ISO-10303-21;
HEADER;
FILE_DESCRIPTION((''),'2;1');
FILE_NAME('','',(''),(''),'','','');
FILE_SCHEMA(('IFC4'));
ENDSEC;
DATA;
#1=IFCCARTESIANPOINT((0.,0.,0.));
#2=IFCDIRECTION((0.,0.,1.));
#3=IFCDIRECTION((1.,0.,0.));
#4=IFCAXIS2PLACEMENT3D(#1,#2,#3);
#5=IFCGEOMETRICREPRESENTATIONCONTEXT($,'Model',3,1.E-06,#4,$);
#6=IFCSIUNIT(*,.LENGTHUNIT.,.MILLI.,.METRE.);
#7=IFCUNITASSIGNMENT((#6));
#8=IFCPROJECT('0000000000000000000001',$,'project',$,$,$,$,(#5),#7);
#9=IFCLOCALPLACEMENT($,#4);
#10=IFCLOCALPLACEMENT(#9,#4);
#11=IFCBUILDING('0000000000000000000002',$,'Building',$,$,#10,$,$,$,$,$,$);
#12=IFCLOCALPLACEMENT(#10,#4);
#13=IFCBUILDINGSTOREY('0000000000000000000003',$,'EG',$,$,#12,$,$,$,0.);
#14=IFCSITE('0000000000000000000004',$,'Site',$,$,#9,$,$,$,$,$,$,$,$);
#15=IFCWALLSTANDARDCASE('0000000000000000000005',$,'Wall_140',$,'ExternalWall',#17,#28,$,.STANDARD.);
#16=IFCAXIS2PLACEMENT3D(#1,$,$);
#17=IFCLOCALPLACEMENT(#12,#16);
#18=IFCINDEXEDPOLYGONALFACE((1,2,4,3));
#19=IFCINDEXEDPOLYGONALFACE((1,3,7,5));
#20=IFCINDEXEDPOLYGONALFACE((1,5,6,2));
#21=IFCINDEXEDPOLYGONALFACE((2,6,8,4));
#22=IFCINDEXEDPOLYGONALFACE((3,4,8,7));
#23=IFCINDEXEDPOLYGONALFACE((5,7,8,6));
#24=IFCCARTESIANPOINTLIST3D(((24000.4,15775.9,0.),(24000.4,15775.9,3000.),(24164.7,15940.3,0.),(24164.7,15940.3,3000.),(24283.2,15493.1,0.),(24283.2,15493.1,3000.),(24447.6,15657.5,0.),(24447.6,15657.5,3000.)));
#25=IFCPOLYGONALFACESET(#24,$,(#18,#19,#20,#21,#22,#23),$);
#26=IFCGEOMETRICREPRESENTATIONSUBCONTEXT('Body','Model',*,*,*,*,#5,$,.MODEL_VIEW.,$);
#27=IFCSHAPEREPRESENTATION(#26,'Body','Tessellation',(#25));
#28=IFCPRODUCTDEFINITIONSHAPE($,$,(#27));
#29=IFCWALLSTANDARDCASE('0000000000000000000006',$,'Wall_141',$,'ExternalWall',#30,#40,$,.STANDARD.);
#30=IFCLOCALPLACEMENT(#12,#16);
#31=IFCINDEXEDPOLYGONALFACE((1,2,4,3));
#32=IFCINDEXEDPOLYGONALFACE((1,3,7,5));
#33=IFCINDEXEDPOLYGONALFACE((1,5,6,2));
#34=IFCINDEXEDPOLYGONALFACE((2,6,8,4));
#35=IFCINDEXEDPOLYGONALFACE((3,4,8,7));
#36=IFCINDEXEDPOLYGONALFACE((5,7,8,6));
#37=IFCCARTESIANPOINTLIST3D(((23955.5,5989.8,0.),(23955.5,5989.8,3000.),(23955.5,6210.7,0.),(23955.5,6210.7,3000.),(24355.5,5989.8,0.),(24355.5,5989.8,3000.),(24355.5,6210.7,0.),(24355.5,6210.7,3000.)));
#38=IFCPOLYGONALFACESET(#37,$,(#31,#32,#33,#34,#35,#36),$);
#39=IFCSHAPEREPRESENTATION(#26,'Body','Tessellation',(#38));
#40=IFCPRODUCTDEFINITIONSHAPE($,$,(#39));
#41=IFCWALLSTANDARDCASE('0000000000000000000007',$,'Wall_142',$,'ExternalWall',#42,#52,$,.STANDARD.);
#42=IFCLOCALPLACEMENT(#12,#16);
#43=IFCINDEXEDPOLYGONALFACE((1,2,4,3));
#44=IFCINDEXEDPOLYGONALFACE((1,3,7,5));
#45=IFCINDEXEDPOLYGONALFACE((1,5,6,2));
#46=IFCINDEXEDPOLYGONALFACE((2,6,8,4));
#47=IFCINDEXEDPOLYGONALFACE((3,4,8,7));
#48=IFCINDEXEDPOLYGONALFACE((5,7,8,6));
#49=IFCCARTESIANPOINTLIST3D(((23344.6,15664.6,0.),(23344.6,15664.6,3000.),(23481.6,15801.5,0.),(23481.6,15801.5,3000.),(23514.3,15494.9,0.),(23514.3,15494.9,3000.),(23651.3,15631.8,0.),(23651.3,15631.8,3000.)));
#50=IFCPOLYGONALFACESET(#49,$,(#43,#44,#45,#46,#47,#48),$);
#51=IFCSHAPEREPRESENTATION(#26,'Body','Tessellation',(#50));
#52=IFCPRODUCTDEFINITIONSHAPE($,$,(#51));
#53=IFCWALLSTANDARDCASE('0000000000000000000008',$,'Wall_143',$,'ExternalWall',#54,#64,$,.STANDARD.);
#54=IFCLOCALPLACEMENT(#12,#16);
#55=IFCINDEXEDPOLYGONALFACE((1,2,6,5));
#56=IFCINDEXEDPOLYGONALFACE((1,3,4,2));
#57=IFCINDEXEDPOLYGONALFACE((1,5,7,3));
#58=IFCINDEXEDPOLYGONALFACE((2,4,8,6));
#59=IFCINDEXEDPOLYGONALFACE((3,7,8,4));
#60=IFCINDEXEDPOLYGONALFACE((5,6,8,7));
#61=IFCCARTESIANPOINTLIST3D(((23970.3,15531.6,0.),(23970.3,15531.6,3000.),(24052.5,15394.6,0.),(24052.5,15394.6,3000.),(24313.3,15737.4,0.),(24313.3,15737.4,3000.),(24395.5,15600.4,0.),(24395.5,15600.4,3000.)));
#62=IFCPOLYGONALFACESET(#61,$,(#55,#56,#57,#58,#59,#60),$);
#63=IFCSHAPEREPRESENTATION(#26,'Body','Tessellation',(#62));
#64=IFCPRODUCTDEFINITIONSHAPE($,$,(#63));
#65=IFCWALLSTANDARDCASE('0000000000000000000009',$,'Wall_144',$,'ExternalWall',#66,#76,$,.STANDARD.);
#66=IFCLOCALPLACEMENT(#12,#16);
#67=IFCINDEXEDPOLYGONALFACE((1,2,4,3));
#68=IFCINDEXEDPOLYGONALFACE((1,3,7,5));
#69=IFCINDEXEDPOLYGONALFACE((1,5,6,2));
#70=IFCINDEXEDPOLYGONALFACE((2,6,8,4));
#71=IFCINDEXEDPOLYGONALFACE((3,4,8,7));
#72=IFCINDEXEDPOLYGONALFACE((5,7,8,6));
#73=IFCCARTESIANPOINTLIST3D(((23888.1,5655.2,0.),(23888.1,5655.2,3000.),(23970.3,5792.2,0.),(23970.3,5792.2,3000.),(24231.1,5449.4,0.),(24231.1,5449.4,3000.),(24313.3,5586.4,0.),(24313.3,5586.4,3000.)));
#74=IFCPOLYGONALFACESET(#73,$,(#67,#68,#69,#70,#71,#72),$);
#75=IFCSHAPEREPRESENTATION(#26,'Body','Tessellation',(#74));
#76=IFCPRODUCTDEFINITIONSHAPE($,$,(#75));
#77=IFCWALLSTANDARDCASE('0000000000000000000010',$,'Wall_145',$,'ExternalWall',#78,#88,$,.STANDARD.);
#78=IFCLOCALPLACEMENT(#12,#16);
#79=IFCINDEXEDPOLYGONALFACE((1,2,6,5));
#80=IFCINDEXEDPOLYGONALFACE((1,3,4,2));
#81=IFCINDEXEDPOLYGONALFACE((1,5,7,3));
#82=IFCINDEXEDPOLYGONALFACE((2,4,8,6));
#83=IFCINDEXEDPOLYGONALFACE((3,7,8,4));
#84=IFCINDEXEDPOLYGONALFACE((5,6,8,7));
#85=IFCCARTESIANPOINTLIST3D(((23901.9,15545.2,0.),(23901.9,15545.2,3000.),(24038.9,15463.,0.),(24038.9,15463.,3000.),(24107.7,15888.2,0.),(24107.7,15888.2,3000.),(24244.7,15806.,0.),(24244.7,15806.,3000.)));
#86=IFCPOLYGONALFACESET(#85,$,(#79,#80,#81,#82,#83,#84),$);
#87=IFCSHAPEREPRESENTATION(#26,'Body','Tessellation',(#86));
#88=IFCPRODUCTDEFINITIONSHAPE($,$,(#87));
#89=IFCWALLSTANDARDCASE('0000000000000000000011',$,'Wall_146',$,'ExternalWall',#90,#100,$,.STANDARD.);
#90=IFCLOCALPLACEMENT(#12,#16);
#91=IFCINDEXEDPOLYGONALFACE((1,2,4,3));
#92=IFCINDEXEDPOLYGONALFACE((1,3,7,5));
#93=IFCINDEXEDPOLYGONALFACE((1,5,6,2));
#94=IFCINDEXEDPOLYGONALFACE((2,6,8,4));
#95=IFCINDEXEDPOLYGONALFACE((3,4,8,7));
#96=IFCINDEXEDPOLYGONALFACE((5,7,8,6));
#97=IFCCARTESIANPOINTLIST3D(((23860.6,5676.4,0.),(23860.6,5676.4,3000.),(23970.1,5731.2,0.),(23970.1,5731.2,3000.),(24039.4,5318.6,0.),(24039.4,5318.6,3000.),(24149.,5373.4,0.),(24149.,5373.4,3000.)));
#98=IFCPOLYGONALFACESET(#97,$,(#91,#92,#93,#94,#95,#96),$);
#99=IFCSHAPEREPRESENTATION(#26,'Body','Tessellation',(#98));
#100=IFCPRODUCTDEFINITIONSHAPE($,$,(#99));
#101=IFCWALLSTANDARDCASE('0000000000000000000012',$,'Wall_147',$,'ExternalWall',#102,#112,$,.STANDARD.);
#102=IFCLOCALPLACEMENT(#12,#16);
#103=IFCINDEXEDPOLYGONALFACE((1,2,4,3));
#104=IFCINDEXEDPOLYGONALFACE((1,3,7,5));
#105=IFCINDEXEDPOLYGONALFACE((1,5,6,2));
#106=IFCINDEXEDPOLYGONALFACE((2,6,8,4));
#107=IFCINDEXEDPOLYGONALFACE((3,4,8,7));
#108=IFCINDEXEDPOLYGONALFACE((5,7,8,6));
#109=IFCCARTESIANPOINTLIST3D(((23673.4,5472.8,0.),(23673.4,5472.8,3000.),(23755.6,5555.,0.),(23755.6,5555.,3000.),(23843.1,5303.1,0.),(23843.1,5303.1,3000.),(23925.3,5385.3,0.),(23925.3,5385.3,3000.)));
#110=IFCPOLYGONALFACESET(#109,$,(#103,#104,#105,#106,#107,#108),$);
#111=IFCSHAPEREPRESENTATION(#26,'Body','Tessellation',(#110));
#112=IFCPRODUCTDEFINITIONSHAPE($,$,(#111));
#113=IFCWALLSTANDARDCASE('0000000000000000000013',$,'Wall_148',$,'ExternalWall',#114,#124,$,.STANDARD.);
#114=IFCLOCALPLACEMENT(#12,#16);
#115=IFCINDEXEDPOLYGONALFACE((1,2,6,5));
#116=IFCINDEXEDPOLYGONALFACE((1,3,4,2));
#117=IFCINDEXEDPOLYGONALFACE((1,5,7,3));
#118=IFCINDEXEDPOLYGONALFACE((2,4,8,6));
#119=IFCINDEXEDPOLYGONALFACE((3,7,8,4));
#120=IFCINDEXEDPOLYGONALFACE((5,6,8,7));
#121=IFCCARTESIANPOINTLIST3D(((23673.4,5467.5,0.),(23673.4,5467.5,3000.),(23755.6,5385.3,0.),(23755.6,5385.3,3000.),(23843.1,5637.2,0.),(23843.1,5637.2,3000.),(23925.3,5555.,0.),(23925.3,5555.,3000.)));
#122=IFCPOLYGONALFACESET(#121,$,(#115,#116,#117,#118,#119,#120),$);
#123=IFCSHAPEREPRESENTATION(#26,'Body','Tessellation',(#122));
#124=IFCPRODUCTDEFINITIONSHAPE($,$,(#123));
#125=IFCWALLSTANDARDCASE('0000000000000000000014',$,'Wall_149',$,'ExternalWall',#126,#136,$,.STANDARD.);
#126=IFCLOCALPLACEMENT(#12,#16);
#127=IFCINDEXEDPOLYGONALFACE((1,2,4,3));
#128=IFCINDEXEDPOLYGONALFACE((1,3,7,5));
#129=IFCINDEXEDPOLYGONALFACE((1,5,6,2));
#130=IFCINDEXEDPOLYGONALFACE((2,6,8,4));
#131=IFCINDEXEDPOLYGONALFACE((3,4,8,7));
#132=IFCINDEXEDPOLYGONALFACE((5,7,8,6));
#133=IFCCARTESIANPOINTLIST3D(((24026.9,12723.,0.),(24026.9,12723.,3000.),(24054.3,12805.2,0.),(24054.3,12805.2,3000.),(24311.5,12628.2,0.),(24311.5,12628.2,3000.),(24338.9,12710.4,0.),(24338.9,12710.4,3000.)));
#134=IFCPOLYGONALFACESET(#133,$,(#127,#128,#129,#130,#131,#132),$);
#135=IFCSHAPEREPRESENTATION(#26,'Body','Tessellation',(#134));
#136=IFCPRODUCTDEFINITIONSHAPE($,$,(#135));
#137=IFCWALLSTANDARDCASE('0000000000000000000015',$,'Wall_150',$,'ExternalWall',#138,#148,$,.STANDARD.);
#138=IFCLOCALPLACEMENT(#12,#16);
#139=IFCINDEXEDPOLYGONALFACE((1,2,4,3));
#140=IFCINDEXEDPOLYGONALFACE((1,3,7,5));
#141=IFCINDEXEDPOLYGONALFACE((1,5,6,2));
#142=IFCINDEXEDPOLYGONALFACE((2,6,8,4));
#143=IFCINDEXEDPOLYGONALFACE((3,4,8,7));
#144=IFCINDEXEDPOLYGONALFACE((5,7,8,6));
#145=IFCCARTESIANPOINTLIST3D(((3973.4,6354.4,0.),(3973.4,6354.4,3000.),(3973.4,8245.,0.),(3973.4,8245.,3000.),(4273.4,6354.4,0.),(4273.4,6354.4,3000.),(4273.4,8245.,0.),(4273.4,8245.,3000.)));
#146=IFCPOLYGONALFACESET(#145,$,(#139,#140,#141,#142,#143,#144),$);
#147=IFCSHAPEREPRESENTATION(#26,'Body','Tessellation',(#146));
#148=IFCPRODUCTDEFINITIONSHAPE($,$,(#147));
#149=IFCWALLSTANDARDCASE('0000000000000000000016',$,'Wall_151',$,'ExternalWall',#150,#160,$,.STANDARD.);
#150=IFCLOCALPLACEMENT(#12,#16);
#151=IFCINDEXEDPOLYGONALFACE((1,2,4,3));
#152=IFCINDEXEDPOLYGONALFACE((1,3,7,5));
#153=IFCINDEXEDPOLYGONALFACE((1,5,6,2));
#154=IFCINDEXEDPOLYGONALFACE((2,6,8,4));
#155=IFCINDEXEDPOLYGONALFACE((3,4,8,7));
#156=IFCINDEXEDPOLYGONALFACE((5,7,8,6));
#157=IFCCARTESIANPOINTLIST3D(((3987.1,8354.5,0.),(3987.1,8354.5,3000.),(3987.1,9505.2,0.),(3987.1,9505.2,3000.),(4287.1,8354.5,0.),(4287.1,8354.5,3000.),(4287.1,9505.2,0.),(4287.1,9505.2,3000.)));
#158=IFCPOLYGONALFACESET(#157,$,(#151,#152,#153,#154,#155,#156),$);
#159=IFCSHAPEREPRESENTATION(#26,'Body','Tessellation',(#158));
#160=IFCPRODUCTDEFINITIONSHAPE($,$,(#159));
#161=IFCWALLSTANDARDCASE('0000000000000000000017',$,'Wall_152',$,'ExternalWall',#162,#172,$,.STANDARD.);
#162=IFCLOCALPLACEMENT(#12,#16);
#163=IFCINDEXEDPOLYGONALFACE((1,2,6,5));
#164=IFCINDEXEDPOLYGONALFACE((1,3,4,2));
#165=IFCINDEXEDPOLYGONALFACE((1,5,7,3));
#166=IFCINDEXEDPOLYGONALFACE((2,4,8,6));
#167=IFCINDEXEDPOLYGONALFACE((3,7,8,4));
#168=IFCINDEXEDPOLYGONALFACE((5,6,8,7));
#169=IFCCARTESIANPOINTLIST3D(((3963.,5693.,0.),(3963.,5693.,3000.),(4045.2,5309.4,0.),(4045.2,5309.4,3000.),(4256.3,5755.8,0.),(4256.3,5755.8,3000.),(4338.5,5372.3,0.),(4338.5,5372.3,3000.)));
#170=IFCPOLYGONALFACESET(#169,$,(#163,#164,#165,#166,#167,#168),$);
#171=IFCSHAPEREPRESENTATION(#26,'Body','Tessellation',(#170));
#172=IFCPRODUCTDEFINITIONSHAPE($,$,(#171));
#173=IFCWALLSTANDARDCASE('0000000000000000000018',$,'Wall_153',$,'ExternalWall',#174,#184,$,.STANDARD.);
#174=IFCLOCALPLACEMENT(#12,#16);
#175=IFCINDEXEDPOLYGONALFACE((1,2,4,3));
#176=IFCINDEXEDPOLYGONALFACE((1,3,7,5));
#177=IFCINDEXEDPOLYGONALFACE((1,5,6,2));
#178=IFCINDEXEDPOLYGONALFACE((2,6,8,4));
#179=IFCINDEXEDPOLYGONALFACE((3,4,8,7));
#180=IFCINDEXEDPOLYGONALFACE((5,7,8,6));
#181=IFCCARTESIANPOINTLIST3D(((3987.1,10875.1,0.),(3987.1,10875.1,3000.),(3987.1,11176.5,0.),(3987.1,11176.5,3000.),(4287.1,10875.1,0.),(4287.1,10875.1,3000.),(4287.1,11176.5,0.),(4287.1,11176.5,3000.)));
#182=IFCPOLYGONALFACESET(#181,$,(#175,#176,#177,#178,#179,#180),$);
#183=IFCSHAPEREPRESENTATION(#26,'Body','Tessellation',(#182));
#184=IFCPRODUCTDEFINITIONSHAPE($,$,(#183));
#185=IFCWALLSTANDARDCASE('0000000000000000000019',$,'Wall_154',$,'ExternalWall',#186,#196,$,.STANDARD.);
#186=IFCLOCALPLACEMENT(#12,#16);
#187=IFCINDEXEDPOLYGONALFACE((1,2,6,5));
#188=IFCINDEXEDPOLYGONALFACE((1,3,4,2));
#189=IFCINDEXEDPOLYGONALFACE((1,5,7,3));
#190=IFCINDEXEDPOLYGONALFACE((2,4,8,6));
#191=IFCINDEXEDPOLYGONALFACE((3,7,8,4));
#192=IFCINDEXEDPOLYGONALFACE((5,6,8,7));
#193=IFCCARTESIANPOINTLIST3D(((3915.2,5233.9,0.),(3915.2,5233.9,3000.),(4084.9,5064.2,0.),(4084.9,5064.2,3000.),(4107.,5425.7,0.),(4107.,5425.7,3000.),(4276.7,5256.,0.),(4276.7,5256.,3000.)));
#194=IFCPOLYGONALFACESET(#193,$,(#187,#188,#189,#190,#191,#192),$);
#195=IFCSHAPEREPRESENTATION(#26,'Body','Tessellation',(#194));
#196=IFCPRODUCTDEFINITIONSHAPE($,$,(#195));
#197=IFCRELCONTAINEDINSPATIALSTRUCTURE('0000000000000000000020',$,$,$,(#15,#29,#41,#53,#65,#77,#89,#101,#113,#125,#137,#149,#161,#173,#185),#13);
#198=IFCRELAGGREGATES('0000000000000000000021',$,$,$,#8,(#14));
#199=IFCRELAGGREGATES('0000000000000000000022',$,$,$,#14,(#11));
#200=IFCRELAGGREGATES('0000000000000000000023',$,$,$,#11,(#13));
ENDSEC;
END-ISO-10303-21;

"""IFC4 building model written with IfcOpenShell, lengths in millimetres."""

from ifc_helpers import new_model, si_unit, frame, origin_with_axes, place, context, subcontext, project, spatial, rectangle, extrude, element, save


model = new_model("IFC4")

# Units and contexts
model_context = context("Model", 3, precision=1e-06, world=origin_with_axes())
body_context = subcontext(model_context, "Body", "Model", "MODEL_VIEW")
ifc_project = project(units=[si_unit("LENGTHUNIT", "METRE", prefix="MILLI")], contexts=[model_context])

# Site, building, storey
site_placement = place(None, origin_with_axes())
site = spatial("IfcSite", under=ifc_project, at=site_placement, Name="Site")
building_placement = place(site_placement, origin_with_axes())
building = spatial("IfcBuilding", under=site, at=building_placement, Name="Building")
storey_placement = place(building_placement, origin_with_axes())
storey = spatial("IfcBuildingStorey", under=building, at=storey_placement, Name="EG", Elevation=0.0)

# Walls
wall_1_placement = place(storey_placement, origin_with_axes())
element("IfcWallStandardCase", 1, at=wall_1_placement, inside=storey, Name="Wall_140", ObjectType="ExternalWall", PredefinedType="STANDARD", context=body_context, shape_type="SweptSolid", body=[
    extrude(rectangle(XDim=232.5, YDim=400.0), frame((24224.0, 15716.7, 0.0), z_axis=(0.0, 0.0, 1.0), x_axis=(0.707107, 0.707107, 0.0)), (0.0, 0.0, 1.0), 3000.0),
])
wall_2_placement = place(storey_placement, origin_with_axes())
element("IfcWallStandardCase", 2, at=wall_2_placement, inside=storey, Name="Wall_141", ObjectType="ExternalWall", PredefinedType="STANDARD", context=body_context, shape_type="SweptSolid", body=[
    extrude(rectangle(XDim=220.9, YDim=400.0), frame((24155.5, 6100.3, 0.0), z_axis=(0.0, 0.0, 1.0), x_axis=(0.0, -1.0, 0.0)), (0.0, 0.0, 1.0), 3000.0),
])
wall_3_placement = place(storey_placement, origin_with_axes())
element("IfcWallStandardCase", 3, at=wall_3_placement, inside=storey, Name="Wall_142", ObjectType="ExternalWall", PredefinedType="STANDARD", context=body_context, shape_type="SweptSolid", body=[
    extrude(rectangle(XDim=193.7, YDim=240.0), frame((23497.9, 15648.2, 0.0), z_axis=(0.0, 0.0, 1.0), x_axis=(-0.707107, -0.707107, 0.0)), (0.0, 0.0, 1.0), 3000.0),
])
wall_4_placement = place(storey_placement, origin_with_axes())
element("IfcWallStandardCase", 4, at=wall_4_placement, inside=storey, Name="Wall_143", ObjectType="ExternalWall", PredefinedType="STANDARD", context=body_context, shape_type="SweptSolid", body=[
    extrude(rectangle(XDim=159.8, YDim=400.0), frame((24182.9, 15566.0, 0.0), z_axis=(0.0, 0.0, 1.0), x_axis=(-0.514496, 0.857493, 0.0)), (0.0, 0.0, 1.0), 3000.0),
])
wall_5_placement = place(storey_placement, origin_with_axes())
element("IfcWallStandardCase", 5, at=wall_5_placement, inside=storey, Name="Wall_144", ObjectType="ExternalWall", PredefinedType="STANDARD", context=body_context, shape_type="SweptSolid", body=[
    extrude(rectangle(XDim=159.8, YDim=400.0), frame((24100.7, 5620.8, 0.0), z_axis=(0.0, 0.0, 1.0), x_axis=(-0.514496, -0.857493, 0.0)), (0.0, 0.0, 1.0), 3000.0),
])
wall_6_placement = place(storey_placement, origin_with_axes())
element("IfcWallStandardCase", 6, at=wall_6_placement, inside=storey, Name="Wall_145", ObjectType="ExternalWall", PredefinedType="STANDARD", context=body_context, shape_type="SweptSolid", body=[
    extrude(rectangle(XDim=159.8, YDim=400.0), frame((24073.3, 15675.6, 0.0), z_axis=(0.0, 0.0, 1.0), x_axis=(-0.857493, 0.514496, 0.0)), (0.0, 0.0, 1.0), 3000.0),
])
wall_7_placement = place(storey_placement, origin_with_axes())
element("IfcWallStandardCase", 7, at=wall_7_placement, inside=storey, Name="Wall_146", ObjectType="ExternalWall", PredefinedType="STANDARD", context=body_context, shape_type="SweptSolid", body=[
    extrude(rectangle(XDim=122.5, YDim=400.0), frame((24004.8, 5524.9, 0.0), z_axis=(0.0, 0.0, 1.0), x_axis=(-0.894427, -0.447214, 0.0)), (0.0, 0.0, 1.0), 3000.0),
])
wall_8_placement = place(storey_placement, origin_with_axes())
element("IfcWallStandardCase", 8, at=wall_8_placement, inside=storey, Name="Wall_147", ObjectType="ExternalWall", PredefinedType="STANDARD", context=body_context, shape_type="SweptSolid", body=[
    extrude(rectangle(XDim=116.2, YDim=240.0), frame((23799.3, 5429.0, 0.0), z_axis=(0.0, 0.0, 1.0), x_axis=(-0.707107, -0.707107, 0.0)), (0.0, 0.0, 1.0), 3000.0),
])
wall_9_placement = place(storey_placement, origin_with_axes())
element("IfcWallStandardCase", 9, at=wall_9_placement, inside=storey, Name="Wall_148", ObjectType="ExternalWall", PredefinedType="STANDARD", context=body_context, shape_type="SweptSolid", body=[
    extrude(rectangle(XDim=116.2, YDim=240.0), frame((23799.3, 5511.2, 0.0), z_axis=(0.0, 0.0, 1.0), x_axis=(-0.707107, 0.707107, 0.0)), (0.0, 0.0, 1.0), 3000.0),
])
wall_10_placement = place(storey_placement, origin_with_axes())
element("IfcWallStandardCase", 10, at=wall_10_placement, inside=storey, Name="Wall_149", ObjectType="ExternalWall", PredefinedType="STANDARD", context=body_context, shape_type="SweptSolid", body=[
    extrude(rectangle(XDim=86.6, YDim=300.0), frame((24182.9, 12716.7, 0.0), z_axis=(0.0, 0.0, 1.0), x_axis=(0.316228, 0.948683, 0.0)), (0.0, 0.0, 1.0), 3000.0),
])
wall_11_placement = place(storey_placement, origin_with_axes())
element("IfcWallStandardCase", 11, at=wall_11_placement, inside=storey, Name="Wall_150", ObjectType="ExternalWall", PredefinedType="STANDARD", context=body_context, shape_type="SweptSolid", body=[
    extrude(rectangle(XDim=1890.6, YDim=300.0), frame((4123.4, 7299.7, 0.0), z_axis=(0.0, 0.0, 1.0), x_axis=(0.0, 1.0, 0.0)), (0.0, 0.0, 1.0), 3000.0),
])
wall_12_placement = place(storey_placement, origin_with_axes())
element("IfcWallStandardCase", 12, at=wall_12_placement, inside=storey, Name="Wall_151", ObjectType="ExternalWall", PredefinedType="STANDARD", context=body_context, shape_type="SweptSolid", body=[
    extrude(rectangle(XDim=1150.7, YDim=300.0), frame((4137.1, 8929.9, 0.0), z_axis=(0.0, 0.0, 1.0), x_axis=(0.0, 1.0, 0.0)), (0.0, 0.0, 1.0), 3000.0),
])
wall_13_placement = place(storey_placement, origin_with_axes())
element("IfcWallStandardCase", 13, at=wall_13_placement, inside=storey, Name="Wall_152", ObjectType="ExternalWall", PredefinedType="STANDARD", context=body_context, shape_type="SweptSolid", body=[
    extrude(rectangle(XDim=392.3, YDim=300.0), frame((4150.8, 5532.6, 0.0), z_axis=(0.0, 0.0, 1.0), x_axis=(-0.209529, 0.977802, 0.0)), (0.0, 0.0, 1.0), 3000.0),
])
wall_14_placement = place(storey_placement, origin_with_axes())
element("IfcWallStandardCase", 14, at=wall_14_placement, inside=storey, Name="Wall_153", ObjectType="ExternalWall", PredefinedType="STANDARD", context=body_context, shape_type="SweptSolid", body=[
    extrude(rectangle(XDim=301.4, YDim=300.0), frame((4137.1, 11025.8, 0.0), z_axis=(0.0, 0.0, 1.0), x_axis=(0.0, 1.0, 0.0)), (0.0, 0.0, 1.0), 3000.0),
])
wall_15_placement = place(storey_placement, origin_with_axes())
element("IfcWallStandardCase", 15, at=wall_15_placement, inside=storey, Name="Wall_154", ObjectType="ExternalWall", PredefinedType="STANDARD", context=body_context, shape_type="SweptSolid", body=[
    extrude(rectangle(XDim=271.2, YDim=240.0), frame((4096.0, 5244.9, 0.0), z_axis=(0.0, 0.0, 1.0), x_axis=(-0.707107, -0.707107, 0.0)), (0.0, 0.0, 1.0), 3000.0),
])

save(model, "model.ifc")
